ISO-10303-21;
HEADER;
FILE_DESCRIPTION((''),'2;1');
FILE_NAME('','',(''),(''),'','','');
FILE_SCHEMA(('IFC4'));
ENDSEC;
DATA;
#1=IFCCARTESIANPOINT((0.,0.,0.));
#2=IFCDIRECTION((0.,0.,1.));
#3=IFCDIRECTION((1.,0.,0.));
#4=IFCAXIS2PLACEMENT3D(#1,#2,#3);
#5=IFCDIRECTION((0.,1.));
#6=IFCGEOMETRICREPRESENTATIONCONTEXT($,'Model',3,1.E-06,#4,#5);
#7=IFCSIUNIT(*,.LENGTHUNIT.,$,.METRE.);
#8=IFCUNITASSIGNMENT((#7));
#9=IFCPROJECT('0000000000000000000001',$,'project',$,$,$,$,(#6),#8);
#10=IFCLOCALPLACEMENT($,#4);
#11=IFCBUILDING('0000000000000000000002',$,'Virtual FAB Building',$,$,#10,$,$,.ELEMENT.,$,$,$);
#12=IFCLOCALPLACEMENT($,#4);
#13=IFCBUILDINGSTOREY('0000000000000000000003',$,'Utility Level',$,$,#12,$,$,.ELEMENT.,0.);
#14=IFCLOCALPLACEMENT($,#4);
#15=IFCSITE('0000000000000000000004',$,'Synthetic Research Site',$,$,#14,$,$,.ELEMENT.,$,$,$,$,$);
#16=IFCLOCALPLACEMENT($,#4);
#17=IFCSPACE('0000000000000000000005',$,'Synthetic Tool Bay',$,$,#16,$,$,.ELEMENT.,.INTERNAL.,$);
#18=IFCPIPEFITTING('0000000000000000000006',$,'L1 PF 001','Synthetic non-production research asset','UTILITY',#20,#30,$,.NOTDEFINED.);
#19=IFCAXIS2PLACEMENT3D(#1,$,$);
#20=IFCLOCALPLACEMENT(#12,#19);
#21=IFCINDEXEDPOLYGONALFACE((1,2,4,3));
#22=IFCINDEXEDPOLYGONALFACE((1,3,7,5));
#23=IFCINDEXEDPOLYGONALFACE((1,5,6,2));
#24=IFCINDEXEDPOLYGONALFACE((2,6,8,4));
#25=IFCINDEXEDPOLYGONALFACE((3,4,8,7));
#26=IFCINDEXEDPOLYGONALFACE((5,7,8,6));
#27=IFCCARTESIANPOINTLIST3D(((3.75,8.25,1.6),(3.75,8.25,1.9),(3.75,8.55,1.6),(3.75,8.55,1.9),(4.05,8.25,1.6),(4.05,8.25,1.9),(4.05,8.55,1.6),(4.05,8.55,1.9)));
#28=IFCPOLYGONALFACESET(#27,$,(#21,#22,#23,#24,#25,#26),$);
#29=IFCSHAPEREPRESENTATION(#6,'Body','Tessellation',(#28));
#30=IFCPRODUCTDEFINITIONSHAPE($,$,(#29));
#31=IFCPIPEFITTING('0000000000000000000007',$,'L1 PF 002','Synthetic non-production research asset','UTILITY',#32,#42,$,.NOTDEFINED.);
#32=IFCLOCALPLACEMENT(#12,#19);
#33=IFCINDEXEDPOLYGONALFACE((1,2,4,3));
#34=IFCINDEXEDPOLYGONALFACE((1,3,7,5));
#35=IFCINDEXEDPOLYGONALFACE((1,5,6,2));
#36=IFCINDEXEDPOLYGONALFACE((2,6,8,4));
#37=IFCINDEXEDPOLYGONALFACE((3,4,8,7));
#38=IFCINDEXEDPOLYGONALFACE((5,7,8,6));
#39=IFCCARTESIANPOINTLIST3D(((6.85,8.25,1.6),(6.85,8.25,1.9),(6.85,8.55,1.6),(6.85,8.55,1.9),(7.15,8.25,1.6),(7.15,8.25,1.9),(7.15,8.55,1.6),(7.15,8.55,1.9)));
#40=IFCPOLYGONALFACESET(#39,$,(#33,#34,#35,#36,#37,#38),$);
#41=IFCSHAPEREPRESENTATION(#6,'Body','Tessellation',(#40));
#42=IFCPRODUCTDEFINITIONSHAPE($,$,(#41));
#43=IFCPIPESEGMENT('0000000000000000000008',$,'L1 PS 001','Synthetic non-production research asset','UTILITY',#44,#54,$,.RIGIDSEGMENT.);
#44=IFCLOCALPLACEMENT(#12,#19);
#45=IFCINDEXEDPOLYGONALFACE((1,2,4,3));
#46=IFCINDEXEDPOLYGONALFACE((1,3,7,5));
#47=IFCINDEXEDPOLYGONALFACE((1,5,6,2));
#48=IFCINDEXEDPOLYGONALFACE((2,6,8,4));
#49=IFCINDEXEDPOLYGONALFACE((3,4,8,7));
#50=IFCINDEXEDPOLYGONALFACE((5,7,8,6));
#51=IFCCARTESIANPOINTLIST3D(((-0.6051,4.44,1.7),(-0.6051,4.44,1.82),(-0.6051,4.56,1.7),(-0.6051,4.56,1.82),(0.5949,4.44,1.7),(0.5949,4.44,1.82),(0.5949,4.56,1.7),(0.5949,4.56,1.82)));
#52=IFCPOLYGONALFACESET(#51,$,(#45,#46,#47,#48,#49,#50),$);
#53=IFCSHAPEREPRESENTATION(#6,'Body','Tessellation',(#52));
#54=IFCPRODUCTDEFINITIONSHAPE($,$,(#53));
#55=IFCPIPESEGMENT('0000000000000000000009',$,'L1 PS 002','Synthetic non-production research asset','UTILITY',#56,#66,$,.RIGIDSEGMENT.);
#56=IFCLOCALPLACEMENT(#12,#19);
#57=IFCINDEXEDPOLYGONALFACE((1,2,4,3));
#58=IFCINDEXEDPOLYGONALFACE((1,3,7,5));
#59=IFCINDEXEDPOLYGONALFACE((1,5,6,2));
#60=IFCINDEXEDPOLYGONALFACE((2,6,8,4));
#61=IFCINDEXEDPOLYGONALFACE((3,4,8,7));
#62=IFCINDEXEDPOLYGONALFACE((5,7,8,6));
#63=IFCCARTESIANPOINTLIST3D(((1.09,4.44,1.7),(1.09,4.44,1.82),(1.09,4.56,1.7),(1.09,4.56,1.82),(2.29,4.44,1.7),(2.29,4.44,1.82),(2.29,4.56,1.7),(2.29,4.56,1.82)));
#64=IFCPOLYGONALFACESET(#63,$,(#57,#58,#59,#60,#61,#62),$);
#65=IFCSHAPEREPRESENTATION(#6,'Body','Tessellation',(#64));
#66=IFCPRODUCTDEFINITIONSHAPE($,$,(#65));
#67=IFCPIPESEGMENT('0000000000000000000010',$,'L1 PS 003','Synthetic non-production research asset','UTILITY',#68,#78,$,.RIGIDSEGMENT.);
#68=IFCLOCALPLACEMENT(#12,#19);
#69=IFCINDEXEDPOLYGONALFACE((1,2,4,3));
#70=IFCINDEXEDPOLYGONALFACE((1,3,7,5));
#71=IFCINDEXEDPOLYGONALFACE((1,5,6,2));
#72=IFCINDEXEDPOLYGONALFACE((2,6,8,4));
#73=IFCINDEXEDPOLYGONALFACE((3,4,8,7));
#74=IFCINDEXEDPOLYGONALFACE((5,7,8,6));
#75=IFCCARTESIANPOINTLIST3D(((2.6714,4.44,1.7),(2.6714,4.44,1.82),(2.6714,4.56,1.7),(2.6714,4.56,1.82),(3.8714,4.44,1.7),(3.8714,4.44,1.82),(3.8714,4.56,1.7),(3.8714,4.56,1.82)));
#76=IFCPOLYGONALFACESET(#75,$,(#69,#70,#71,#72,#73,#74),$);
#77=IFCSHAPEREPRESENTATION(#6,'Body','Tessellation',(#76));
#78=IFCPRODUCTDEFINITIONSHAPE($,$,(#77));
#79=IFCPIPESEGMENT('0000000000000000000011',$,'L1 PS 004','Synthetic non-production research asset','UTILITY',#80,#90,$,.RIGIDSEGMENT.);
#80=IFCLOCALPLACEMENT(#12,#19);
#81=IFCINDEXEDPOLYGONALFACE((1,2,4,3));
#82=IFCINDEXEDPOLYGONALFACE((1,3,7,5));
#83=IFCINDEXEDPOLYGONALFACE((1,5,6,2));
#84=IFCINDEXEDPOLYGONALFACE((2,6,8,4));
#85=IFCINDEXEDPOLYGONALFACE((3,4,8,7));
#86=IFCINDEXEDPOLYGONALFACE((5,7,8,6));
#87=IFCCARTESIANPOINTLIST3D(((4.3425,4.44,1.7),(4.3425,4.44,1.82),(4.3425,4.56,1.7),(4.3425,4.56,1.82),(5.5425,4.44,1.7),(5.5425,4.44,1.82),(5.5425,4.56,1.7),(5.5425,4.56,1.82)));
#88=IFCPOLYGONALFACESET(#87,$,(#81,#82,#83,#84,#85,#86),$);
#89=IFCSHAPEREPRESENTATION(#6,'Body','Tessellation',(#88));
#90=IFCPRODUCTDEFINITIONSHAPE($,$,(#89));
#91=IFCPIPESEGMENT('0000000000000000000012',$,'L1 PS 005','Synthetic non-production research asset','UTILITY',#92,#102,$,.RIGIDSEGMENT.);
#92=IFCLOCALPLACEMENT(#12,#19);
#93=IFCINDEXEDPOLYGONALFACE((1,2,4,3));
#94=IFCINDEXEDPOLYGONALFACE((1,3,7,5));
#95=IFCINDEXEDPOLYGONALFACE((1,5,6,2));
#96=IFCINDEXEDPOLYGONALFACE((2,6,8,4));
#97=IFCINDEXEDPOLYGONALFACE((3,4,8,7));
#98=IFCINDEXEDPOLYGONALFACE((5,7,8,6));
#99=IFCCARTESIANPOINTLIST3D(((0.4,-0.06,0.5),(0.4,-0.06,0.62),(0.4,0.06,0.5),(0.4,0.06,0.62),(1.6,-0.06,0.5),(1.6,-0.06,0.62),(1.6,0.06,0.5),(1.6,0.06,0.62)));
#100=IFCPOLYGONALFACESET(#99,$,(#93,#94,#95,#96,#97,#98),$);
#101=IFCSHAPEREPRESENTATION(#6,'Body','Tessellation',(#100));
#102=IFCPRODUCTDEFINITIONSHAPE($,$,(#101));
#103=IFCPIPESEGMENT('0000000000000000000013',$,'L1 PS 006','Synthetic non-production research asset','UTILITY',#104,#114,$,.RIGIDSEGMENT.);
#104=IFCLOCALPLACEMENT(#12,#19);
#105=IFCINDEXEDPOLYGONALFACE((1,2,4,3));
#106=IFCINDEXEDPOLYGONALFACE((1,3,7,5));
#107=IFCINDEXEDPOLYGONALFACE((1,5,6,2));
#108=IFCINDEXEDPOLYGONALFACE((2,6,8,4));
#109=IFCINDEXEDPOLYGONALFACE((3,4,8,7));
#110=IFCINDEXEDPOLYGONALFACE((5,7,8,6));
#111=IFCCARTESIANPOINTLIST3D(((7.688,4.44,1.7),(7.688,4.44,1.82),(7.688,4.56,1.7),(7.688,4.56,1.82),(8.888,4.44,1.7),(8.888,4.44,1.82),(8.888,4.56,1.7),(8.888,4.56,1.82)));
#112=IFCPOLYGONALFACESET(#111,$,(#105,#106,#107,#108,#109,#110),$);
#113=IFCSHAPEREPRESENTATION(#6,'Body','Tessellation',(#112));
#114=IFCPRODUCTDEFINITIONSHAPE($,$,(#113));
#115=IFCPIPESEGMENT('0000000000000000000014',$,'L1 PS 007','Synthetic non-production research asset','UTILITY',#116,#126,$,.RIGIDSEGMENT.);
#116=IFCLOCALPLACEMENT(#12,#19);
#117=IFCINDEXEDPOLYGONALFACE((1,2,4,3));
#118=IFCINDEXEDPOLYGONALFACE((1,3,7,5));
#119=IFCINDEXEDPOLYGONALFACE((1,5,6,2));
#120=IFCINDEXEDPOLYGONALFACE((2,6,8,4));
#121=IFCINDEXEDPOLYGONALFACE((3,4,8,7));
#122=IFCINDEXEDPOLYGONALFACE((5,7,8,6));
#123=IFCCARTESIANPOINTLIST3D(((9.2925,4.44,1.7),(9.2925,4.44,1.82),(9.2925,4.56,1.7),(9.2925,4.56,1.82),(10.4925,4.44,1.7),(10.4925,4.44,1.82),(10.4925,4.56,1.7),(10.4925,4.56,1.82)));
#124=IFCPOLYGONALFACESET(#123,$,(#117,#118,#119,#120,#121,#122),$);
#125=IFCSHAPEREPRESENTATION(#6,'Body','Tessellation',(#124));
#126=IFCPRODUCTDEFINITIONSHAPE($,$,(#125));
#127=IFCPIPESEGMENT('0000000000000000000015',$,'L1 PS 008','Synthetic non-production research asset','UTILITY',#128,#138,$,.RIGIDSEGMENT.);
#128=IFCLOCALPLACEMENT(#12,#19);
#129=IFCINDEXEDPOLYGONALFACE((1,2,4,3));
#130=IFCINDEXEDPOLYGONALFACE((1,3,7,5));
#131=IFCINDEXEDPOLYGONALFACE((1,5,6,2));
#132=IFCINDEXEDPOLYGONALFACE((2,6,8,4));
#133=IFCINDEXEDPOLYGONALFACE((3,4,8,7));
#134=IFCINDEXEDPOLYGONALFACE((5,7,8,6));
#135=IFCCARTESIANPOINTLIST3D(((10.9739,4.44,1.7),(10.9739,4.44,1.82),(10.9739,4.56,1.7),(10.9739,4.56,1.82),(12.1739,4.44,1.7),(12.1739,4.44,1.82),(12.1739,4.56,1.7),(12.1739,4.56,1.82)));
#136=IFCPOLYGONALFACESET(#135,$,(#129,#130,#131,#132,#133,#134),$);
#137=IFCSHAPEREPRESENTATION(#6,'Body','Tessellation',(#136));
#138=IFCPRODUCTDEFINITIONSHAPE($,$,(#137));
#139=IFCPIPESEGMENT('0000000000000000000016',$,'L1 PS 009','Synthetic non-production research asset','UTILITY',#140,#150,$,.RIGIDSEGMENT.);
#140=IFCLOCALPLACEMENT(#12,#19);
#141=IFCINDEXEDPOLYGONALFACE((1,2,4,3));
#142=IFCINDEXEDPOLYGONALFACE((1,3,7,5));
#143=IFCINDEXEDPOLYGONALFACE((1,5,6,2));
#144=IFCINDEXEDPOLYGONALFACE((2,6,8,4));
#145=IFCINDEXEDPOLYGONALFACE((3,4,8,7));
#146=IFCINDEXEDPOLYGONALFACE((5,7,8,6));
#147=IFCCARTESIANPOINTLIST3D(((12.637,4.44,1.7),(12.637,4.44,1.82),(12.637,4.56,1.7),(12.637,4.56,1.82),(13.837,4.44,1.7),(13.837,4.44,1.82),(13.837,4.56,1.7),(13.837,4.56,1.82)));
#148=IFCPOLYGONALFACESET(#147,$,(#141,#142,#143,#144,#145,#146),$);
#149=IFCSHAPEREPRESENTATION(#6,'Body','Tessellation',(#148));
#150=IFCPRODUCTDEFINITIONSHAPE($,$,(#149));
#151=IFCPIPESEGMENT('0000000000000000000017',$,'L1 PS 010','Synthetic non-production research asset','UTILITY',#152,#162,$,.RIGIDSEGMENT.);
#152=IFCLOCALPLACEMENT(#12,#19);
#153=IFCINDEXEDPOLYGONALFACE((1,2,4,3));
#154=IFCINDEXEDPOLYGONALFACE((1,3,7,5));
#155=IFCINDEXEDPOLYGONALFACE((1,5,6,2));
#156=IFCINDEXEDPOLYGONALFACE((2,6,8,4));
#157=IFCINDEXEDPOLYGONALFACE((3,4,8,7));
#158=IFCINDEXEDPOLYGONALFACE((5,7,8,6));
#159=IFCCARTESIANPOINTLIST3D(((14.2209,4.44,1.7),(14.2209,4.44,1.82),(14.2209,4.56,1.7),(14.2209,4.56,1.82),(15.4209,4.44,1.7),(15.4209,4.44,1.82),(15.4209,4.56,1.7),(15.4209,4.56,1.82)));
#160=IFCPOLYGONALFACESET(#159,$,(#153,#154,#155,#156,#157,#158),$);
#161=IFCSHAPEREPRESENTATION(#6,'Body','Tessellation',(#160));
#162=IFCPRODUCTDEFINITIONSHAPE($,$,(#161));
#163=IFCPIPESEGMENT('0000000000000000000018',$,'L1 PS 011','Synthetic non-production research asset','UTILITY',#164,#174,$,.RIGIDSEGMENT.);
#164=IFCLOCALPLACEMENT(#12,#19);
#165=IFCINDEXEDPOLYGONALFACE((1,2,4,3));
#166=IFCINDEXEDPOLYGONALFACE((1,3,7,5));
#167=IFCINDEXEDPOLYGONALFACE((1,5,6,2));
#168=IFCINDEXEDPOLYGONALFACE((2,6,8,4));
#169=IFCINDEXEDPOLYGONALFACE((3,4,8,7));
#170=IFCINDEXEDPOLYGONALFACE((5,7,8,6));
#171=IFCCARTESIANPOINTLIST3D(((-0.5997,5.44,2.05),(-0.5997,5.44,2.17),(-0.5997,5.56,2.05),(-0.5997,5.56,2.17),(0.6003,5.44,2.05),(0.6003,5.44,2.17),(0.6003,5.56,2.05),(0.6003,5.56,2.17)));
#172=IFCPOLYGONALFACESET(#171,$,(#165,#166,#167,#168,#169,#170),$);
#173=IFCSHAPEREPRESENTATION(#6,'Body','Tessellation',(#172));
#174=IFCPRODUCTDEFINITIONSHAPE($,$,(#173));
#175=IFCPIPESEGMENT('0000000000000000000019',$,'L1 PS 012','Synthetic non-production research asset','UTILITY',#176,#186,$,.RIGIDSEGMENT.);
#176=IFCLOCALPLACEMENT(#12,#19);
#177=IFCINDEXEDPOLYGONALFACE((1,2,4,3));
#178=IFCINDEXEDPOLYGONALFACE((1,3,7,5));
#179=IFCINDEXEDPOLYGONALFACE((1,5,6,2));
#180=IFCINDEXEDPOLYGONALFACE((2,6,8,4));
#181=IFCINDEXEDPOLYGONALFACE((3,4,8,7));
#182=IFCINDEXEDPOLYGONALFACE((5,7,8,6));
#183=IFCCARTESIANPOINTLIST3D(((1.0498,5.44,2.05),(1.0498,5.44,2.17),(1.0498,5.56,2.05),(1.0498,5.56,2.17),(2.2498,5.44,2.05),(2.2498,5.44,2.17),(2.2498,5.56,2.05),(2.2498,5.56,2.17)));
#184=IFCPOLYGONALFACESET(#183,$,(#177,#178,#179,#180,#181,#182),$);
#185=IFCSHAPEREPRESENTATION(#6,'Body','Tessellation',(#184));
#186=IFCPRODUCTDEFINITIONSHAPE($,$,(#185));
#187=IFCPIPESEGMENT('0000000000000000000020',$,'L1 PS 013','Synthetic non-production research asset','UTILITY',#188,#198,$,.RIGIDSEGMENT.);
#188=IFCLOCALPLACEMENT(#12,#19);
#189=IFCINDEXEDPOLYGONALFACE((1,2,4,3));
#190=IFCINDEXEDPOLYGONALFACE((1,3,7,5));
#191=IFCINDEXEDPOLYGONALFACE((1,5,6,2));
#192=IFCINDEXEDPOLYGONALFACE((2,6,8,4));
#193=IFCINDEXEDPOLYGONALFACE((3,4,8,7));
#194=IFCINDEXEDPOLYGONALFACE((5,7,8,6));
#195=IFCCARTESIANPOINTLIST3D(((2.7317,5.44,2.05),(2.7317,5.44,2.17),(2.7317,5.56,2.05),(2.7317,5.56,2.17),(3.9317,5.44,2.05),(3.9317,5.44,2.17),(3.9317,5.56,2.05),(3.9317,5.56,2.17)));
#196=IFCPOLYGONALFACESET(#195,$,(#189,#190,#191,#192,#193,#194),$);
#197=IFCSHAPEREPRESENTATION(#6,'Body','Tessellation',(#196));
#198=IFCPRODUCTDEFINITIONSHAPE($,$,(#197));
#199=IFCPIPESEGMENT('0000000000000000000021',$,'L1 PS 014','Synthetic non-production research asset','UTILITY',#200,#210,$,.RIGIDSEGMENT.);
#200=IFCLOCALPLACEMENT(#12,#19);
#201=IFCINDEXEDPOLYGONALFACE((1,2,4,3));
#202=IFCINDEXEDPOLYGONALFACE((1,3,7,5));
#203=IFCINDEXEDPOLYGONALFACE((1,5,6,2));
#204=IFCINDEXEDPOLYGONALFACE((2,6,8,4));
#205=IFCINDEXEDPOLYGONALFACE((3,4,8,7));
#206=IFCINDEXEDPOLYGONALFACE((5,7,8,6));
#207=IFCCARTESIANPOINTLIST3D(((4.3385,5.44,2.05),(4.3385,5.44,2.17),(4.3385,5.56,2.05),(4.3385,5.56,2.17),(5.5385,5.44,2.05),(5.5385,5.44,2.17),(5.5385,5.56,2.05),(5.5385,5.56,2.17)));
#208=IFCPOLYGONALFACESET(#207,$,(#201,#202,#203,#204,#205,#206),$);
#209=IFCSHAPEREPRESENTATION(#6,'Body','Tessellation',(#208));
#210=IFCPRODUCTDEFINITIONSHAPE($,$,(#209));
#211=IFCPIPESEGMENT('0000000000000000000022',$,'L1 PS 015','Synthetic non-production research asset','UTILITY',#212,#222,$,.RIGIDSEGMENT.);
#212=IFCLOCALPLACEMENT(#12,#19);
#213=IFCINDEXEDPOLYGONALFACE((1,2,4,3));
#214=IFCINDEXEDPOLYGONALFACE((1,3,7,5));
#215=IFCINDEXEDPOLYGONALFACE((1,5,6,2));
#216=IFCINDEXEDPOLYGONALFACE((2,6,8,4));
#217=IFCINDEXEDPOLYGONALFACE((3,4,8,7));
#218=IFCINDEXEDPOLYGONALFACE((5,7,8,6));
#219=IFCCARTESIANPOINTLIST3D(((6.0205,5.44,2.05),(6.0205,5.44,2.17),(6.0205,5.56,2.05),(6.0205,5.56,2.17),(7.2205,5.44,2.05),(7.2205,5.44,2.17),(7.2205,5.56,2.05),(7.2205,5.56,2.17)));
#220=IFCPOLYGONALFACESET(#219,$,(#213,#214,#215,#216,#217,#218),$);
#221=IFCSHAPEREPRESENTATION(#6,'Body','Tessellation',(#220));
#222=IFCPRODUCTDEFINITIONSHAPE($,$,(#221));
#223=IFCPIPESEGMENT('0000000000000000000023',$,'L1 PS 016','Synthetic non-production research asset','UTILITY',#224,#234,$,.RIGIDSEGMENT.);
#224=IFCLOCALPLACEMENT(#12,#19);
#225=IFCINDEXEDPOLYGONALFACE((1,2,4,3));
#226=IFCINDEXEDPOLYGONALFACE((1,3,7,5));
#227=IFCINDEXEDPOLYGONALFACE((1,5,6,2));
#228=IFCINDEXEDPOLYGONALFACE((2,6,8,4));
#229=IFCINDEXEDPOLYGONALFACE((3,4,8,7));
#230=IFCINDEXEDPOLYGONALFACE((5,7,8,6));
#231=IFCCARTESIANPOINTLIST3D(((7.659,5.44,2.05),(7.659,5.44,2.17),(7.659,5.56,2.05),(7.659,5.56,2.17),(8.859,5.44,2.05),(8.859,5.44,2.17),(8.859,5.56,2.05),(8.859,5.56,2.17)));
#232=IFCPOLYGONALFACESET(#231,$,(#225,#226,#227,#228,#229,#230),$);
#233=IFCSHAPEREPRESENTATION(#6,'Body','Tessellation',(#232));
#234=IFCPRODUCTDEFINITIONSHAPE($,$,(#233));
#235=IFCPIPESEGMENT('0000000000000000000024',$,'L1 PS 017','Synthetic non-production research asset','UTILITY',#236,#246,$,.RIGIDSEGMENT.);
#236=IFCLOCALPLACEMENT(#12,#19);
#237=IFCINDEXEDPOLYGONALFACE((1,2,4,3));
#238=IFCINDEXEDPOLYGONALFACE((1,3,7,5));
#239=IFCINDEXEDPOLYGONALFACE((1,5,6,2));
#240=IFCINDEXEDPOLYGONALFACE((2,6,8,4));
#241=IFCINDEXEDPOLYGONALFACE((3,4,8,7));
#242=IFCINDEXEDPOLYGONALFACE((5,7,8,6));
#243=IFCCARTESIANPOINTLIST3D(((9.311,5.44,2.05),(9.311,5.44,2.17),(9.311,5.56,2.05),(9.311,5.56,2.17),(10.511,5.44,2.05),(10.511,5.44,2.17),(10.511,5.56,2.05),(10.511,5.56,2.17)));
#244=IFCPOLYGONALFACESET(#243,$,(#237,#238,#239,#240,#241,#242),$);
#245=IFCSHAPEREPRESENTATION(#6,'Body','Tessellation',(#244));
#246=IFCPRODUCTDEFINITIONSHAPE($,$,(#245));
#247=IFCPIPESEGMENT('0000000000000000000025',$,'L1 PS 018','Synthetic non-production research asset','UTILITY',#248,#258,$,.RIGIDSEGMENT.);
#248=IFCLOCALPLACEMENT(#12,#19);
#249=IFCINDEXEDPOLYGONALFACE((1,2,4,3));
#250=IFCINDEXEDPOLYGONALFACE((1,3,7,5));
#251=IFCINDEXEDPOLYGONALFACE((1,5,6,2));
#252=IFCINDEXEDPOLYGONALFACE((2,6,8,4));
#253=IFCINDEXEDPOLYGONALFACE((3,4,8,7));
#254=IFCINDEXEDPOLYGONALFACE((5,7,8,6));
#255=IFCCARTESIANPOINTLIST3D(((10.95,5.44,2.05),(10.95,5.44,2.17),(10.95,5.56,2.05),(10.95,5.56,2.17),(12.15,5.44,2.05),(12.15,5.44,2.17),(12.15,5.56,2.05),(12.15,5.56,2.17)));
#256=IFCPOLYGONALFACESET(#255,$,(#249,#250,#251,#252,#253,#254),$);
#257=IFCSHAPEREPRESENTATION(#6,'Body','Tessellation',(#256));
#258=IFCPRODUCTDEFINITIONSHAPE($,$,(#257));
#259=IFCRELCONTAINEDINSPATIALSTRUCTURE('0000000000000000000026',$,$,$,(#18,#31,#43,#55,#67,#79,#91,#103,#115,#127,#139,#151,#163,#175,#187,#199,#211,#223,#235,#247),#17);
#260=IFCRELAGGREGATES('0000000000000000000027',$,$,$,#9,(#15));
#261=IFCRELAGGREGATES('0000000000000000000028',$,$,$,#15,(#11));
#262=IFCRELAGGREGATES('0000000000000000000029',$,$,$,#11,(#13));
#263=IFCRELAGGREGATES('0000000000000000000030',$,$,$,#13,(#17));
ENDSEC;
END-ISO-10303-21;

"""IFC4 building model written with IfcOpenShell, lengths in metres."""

from ifc_helpers import new_model, si_unit, direction, frame, origin_with_axes, origin_2d_with_axis, place, context, project, spatial, rectangle, extrude, element, save


model = new_model("IFC4")

# Units and contexts
model_context = context("Model", 3, precision=1e-06, world=origin_with_axes(), true_north=direction((0.0, 1.0)))
ifc_project = project(units=[si_unit("LENGTHUNIT", "METRE")], contexts=[model_context])

# Site, building, storey, space
site_placement = place(None, origin_with_axes())
site = spatial("IfcSite", under=ifc_project, at=site_placement, Name="Synthetic Research Site", CompositionType="ELEMENT")
building_placement = place(None, origin_with_axes())
building = spatial("IfcBuilding", under=site, at=building_placement, Name="Virtual FAB Building", CompositionType="ELEMENT")
storey_placement = place(None, origin_with_axes())
storey = spatial("IfcBuildingStorey", under=building, at=storey_placement, Name="Utility Level", CompositionType="ELEMENT", Elevation=0.0)
space_placement = place(None, origin_with_axes())
space = spatial("IfcSpace", under=storey, at=space_placement, Name="Synthetic Tool Bay", CompositionType="ELEMENT", PredefinedType="INTERNAL")

# Pipe fittings
for number, where, z_axis, x_axis, name in (
    (1, (3.9, 8.4, 1.6), (0.0, 0.0, 1.0), (1.0, 0.0, 0.0), "L1 PF 001"),
    (2, (7.0, 8.4, 1.6), (0.0, 0.0, 1.0), (1.0, 0.0, 0.0), "L1 PF 002"),
):
    element("IfcPipeFitting", number, at=place(None, frame(where, z_axis=z_axis, x_axis=x_axis)), inside=space, Name=name, Description="Synthetic non-production research asset", ObjectType="UTILITY", PredefinedType="NOTDEFINED", context=model_context, shape_type="SweptSolid", body=[
        extrude(rectangle(XDim=0.3, YDim=0.3, at=origin_2d_with_axis()), origin_with_axes(), (0.0, 0.0, 1.0), 0.3),
    ])

# Pipe segments
for number, where, z_axis, x_axis, name in (
    (3, (-0.0051, 4.5, 1.7), (0.0, 0.0, 1.0), (1.0, 0.0, 0.0), "L1 PS 001"),
    (4, (1.69, 4.5, 1.7), (0.0, 0.0, 1.0), (1.0, 0.0, 0.0), "L1 PS 002"),
    (5, (3.2714, 4.5, 1.7), (0.0, 0.0, 1.0), (1.0, 0.0, 0.0), "L1 PS 003"),
    (6, (4.9425, 4.5, 1.7), (0.0, 0.0, 1.0), (1.0, 0.0, 0.0), "L1 PS 004"),
    (7, (1.0, 0.0, 0.5), (0.0, 0.0, 1.0), (1.0, 0.0, 0.0), "L1 PS 005"),
    (8, (8.288, 4.5, 1.7), (0.0, 0.0, 1.0), (1.0, 0.0, 0.0), "L1 PS 006"),
    (9, (9.8925, 4.5, 1.7), (0.0, 0.0, 1.0), (1.0, 0.0, 0.0), "L1 PS 007"),
    (10, (11.5739, 4.5, 1.7), (0.0, 0.0, 1.0), (1.0, 0.0, 0.0), "L1 PS 008"),
    (11, (13.237, 4.5, 1.7), (0.0, 0.0, 1.0), (1.0, 0.0, 0.0), "L1 PS 009"),
    (12, (14.8209, 4.5, 1.7), (0.0, 0.0, 1.0), (1.0, 0.0, 0.0), "L1 PS 010"),
    (13, (0.0003, 5.5, 2.05), (0.0, 0.0, 1.0), (1.0, 0.0, 0.0), "L1 PS 011"),
    (14, (1.6498, 5.5, 2.05), (0.0, 0.0, 1.0), (1.0, 0.0, 0.0), "L1 PS 012"),
    (15, (3.3317, 5.5, 2.05), (0.0, 0.0, 1.0), (1.0, 0.0, 0.0), "L1 PS 013"),
    (16, (4.9385, 5.5, 2.05), (0.0, 0.0, 1.0), (1.0, 0.0, 0.0), "L1 PS 014"),
    (17, (6.6205, 5.5, 2.05), (0.0, 0.0, 1.0), (1.0, 0.0, 0.0), "L1 PS 015"),
    (18, (8.259, 5.5, 2.05), (0.0, 0.0, 1.0), (1.0, 0.0, 0.0), "L1 PS 016"),
    (19, (9.911, 5.5, 2.05), (0.0, 0.0, 1.0), (1.0, 0.0, 0.0), "L1 PS 017"),
    (20, (11.55, 5.5, 2.05), (0.0, 0.0, 1.0), (1.0, 0.0, 0.0), "L1 PS 018"),
):
    element("IfcPipeSegment", number, at=place(None, frame(where, z_axis=z_axis, x_axis=x_axis)), inside=space, Name=name, Description="Synthetic non-production research asset", ObjectType="UTILITY", PredefinedType="RIGIDSEGMENT", context=model_context, shape_type="SweptSolid", body=[
        extrude(rectangle(XDim=1.2, YDim=0.12, at=origin_2d_with_axis()), origin_with_axes(), (0.0, 0.0, 1.0), 0.12),
    ])

save(model, "model.ifc")
